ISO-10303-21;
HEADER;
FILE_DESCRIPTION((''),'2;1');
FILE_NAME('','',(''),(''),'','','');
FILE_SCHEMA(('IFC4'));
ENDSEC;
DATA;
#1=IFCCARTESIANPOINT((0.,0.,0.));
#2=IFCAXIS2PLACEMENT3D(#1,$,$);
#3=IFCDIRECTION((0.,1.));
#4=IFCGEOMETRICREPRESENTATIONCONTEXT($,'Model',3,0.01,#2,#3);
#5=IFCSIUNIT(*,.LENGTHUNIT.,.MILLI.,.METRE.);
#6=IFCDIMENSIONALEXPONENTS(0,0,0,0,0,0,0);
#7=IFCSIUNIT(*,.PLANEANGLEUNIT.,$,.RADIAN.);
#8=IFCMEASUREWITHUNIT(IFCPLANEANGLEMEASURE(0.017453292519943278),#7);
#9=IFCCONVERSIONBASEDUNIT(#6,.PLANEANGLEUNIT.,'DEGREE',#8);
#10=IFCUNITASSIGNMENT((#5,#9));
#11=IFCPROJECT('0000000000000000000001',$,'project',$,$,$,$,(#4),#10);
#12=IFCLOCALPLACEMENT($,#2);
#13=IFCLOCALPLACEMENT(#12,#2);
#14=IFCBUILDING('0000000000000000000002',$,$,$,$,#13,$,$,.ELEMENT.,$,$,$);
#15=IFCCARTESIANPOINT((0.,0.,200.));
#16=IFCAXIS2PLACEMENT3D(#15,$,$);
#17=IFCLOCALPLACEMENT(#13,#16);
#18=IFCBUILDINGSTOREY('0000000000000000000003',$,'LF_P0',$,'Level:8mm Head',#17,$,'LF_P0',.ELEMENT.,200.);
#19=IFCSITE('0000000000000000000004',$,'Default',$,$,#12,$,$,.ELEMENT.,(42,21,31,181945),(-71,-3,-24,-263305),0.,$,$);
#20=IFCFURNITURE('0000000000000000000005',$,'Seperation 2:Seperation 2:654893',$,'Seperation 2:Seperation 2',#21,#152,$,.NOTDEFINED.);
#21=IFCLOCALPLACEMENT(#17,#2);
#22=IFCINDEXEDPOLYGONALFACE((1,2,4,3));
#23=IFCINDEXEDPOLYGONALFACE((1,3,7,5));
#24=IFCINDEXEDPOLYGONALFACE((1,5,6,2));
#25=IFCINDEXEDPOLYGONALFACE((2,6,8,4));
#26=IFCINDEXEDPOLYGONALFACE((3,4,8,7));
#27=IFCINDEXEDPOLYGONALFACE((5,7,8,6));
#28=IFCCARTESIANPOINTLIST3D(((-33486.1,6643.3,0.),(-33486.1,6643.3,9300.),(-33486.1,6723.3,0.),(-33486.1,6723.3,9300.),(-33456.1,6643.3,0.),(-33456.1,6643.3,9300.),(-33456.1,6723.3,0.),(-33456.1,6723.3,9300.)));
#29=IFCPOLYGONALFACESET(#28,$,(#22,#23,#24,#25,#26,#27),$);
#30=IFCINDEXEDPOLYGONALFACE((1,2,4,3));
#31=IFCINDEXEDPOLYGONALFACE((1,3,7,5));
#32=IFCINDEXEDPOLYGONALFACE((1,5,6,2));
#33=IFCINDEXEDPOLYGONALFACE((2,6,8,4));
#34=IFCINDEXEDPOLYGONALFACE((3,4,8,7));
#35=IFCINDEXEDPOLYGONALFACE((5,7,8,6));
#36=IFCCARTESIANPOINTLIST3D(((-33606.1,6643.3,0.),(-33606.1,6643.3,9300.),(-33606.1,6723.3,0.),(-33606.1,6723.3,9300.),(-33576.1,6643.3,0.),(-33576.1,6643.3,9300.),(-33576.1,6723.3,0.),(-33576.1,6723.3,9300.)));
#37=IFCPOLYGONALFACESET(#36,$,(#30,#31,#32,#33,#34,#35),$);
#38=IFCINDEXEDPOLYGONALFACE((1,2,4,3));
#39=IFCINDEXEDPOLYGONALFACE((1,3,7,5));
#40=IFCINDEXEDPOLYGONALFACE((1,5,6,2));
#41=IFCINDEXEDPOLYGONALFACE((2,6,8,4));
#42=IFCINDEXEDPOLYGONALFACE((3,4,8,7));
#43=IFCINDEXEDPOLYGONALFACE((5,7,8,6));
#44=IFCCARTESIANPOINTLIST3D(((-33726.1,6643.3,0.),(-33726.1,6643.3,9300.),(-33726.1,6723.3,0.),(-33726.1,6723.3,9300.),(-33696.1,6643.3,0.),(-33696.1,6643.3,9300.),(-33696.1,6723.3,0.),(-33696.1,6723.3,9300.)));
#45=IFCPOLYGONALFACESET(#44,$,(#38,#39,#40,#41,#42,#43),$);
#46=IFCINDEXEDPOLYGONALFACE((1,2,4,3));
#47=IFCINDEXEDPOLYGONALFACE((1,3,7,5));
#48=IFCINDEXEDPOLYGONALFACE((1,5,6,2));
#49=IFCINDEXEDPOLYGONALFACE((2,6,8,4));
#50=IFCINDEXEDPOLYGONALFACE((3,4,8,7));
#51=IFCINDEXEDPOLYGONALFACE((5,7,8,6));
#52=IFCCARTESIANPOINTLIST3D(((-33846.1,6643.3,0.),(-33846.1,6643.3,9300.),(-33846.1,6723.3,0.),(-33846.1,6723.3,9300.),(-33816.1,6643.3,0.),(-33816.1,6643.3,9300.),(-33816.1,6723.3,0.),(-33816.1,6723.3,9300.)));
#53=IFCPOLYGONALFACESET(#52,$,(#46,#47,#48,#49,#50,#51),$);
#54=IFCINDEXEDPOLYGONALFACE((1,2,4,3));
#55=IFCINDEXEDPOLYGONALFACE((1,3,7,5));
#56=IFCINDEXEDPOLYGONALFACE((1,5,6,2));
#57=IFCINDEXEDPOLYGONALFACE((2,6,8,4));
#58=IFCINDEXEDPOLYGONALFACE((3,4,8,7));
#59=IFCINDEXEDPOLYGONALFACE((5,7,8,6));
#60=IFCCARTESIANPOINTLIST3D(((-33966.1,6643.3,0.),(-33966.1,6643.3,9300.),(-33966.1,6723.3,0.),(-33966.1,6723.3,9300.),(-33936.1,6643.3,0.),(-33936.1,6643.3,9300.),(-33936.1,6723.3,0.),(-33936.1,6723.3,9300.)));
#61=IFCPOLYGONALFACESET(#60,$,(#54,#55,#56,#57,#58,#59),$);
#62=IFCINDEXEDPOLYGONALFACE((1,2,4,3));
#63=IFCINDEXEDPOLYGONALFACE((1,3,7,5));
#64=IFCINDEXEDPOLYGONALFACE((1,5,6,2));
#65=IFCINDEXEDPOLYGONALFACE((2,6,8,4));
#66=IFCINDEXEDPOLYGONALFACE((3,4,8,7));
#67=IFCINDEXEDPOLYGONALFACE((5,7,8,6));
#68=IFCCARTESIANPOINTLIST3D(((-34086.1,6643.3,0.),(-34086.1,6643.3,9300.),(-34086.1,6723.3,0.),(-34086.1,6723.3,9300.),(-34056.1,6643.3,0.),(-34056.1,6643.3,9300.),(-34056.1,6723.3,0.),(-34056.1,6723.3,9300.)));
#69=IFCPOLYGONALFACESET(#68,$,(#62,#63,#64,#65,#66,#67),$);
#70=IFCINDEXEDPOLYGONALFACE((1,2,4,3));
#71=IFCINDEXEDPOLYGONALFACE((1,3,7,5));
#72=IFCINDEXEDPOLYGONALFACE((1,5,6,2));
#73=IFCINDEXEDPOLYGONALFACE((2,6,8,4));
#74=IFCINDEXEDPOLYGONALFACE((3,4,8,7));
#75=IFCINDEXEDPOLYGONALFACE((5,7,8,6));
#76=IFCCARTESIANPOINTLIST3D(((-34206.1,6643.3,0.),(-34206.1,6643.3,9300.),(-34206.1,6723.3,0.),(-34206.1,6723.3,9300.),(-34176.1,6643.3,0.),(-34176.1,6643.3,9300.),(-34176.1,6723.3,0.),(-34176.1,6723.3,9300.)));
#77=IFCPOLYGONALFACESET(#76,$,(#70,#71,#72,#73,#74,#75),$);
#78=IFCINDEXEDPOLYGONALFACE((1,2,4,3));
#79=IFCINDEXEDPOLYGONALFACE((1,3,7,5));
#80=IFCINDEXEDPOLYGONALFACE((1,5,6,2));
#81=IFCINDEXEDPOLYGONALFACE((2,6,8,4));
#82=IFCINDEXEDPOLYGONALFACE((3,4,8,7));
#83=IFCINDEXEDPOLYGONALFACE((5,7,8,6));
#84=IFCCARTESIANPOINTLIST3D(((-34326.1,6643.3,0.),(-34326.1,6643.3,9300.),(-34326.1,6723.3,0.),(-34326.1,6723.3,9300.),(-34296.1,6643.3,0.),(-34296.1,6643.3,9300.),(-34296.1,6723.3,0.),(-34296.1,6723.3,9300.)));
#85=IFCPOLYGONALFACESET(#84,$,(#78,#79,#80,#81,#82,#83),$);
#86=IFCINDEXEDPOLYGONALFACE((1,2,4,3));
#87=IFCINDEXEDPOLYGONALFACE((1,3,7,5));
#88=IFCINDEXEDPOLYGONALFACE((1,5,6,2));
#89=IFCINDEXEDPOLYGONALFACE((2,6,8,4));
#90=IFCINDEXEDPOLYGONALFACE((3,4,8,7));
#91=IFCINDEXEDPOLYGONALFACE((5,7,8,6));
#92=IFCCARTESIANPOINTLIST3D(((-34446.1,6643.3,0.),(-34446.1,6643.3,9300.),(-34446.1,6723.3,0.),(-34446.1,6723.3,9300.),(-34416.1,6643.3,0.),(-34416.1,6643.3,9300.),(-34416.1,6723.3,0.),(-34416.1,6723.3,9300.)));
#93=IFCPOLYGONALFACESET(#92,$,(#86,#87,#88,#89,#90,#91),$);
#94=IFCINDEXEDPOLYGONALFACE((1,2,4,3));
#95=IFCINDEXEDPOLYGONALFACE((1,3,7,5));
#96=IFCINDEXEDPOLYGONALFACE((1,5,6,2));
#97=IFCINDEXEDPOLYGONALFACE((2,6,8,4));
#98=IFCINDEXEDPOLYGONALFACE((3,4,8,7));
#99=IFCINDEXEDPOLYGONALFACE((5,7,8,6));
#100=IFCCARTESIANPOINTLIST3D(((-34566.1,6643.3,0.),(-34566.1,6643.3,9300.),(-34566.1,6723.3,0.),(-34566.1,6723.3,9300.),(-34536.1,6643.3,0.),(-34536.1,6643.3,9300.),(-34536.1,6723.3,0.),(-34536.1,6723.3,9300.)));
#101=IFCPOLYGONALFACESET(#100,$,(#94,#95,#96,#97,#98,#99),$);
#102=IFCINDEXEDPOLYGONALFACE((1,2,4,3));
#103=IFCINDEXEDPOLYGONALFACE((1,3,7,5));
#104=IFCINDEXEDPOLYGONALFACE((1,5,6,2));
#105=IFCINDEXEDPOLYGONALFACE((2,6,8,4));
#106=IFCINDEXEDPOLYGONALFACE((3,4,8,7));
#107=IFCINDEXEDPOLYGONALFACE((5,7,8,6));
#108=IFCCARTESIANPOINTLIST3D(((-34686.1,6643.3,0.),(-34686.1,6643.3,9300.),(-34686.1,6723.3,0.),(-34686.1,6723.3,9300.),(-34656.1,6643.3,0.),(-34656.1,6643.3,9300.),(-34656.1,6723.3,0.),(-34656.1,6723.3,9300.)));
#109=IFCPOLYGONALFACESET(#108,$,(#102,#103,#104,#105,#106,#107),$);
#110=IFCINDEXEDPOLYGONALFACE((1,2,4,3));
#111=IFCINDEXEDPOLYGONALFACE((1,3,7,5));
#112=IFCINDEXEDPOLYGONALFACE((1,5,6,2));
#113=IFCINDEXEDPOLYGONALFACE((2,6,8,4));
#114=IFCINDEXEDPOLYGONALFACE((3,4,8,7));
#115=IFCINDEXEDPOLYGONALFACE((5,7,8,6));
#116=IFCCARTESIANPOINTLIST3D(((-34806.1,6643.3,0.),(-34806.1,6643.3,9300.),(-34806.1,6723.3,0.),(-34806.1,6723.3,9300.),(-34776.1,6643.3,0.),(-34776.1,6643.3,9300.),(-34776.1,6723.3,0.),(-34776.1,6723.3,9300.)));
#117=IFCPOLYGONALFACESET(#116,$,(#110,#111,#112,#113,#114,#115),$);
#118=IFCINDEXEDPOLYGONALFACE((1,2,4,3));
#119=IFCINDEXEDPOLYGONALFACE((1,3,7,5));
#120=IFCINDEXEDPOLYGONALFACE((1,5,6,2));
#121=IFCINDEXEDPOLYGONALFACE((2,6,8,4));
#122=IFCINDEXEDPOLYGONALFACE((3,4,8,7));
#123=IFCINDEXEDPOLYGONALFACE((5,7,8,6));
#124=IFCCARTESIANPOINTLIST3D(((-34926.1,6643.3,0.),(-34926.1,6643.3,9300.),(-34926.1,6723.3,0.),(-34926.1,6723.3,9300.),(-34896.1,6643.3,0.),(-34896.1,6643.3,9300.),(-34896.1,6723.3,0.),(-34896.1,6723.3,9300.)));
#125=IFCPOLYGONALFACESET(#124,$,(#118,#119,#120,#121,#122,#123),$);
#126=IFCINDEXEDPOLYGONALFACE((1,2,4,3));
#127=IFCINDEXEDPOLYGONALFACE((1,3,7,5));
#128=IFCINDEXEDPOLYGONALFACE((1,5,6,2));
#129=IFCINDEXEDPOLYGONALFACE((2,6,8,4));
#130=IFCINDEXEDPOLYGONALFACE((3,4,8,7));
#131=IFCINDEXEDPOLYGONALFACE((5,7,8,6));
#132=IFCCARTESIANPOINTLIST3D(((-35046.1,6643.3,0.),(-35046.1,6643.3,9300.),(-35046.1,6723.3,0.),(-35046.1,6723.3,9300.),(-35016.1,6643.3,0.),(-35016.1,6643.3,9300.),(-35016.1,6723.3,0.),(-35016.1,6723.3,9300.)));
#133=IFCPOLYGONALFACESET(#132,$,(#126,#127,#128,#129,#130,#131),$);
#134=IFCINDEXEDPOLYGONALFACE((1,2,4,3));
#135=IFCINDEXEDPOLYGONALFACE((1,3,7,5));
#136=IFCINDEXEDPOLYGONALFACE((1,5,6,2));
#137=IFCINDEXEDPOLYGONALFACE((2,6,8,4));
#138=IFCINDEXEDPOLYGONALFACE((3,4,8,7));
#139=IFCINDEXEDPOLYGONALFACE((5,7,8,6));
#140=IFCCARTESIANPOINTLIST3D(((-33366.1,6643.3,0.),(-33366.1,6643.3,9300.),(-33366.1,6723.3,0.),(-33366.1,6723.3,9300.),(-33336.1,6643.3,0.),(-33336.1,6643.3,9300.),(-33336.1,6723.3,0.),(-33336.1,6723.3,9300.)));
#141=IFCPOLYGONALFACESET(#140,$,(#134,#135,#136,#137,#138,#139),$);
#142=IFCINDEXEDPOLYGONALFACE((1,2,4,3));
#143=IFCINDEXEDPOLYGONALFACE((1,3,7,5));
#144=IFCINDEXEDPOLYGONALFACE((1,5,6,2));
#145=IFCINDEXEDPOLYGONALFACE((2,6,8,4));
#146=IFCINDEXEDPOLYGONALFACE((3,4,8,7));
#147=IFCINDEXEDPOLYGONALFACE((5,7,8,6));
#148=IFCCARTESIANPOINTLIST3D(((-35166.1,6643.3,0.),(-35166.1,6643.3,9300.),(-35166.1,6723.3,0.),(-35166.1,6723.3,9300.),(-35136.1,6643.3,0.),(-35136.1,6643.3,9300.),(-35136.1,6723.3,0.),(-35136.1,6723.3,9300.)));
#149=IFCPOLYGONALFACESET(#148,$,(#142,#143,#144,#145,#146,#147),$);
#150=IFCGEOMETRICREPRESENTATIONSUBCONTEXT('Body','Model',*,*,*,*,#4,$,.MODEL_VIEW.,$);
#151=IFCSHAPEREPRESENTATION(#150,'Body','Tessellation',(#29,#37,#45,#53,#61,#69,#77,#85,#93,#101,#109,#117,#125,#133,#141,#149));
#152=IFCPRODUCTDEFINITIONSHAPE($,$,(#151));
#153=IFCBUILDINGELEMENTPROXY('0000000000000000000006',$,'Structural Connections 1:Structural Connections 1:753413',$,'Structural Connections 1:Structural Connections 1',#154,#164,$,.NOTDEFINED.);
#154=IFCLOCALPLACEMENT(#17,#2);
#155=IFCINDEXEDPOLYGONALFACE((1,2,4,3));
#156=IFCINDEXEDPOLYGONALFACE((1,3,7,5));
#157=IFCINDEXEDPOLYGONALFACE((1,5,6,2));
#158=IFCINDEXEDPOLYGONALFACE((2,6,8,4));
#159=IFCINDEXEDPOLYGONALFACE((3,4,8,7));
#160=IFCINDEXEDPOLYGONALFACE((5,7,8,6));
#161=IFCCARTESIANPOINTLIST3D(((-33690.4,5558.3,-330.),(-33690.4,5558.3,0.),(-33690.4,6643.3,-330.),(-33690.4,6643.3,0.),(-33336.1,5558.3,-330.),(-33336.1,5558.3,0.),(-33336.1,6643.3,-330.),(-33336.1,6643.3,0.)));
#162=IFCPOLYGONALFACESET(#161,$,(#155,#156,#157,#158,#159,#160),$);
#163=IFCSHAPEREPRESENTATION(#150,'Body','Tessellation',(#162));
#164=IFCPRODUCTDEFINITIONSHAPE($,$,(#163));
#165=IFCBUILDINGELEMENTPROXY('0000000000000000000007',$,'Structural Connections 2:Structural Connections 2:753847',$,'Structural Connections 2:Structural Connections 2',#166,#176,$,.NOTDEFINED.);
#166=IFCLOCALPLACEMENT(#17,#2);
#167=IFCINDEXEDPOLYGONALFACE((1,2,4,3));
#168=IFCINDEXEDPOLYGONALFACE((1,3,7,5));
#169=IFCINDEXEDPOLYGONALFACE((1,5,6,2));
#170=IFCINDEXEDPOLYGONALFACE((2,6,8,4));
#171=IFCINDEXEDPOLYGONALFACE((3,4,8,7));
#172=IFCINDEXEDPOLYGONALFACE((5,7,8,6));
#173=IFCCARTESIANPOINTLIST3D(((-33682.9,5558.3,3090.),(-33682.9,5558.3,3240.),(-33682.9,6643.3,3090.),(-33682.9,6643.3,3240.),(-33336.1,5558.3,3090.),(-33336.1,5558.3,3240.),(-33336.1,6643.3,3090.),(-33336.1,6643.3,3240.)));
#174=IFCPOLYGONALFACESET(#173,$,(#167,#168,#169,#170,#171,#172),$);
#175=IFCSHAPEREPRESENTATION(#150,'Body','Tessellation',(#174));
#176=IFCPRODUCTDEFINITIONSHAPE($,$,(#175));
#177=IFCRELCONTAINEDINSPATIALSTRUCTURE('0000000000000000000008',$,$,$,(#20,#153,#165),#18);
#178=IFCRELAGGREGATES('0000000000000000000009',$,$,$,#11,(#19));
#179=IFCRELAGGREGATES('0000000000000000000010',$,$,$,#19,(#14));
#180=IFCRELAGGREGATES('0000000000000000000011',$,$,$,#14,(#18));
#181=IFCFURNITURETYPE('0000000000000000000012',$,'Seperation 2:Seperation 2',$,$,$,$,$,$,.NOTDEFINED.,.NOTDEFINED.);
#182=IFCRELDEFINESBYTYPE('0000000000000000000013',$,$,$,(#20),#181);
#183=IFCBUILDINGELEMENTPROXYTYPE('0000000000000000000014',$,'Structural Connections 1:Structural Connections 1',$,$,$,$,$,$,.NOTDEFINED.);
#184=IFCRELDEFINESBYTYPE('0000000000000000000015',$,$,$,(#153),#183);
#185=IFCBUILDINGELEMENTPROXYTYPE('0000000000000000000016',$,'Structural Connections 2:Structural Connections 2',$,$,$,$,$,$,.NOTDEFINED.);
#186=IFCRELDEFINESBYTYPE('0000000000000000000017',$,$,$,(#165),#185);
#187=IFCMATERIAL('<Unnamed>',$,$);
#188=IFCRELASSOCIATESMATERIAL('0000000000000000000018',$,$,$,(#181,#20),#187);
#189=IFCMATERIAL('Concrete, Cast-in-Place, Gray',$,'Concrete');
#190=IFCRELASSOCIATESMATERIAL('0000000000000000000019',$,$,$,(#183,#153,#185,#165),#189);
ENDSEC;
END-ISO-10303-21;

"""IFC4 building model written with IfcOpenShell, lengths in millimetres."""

from ifc_helpers import new_model, entity, si_unit, converted_unit, direction, frame, origin, place, context, subcontext, project, spatial, indexed_curve, outline, extrude, source, transform, mapped, material, type_object, type_shapes, element, save


model = new_model("IFC4")

# Units and contexts
model_context = context("Model", 3, precision=0.01, world=origin(), true_north=direction((0.0, 1.0)))
body_context = subcontext(model_context, "Body", "Model", "MODEL_VIEW")
ifc_project = project(units=[si_unit("LENGTHUNIT", "METRE", prefix="MILLI"), converted_unit("PLANEANGLEUNIT", "DEGREE", entity("IfcPlaneAngleMeasure", 0.017453292519943278), si_unit("PLANEANGLEUNIT", "RADIAN"), dimensions=[0, 0, 0, 0, 0, 0, 0])], contexts=[model_context])

# Site, building, storey
site_placement = place(None, origin())
site = spatial("IfcSite", under=ifc_project, at=site_placement, Name="Default", CompositionType="ELEMENT", RefLatitude=(42, 21, 31, 181945), RefLongitude=(-71, -3, -24, -263305), RefElevation=0.0)
building_placement = place(site_placement, origin())
building = spatial("IfcBuilding", under=site, at=building_placement, CompositionType="ELEMENT")
storey_placement = place(building_placement, frame((0.0, 0.0, 200.0)))
storey = spatial("IfcBuildingStorey", under=building, at=storey_placement, Name="LF_P0", ObjectType="Level:8mm Head", LongName="LF_P0", CompositionType="ELEMENT", Elevation=200.0)

# Furniture
ifc_material_1 = material(Name="<Unnamed>")
furniture_type_1 = type_object("IfcFurnitureType", Name="Seperation 2:Seperation 2", AssemblyPlace="NOTDEFINED", PredefinedType="NOTDEFINED", material=ifc_material_1)
shared_shape_1 = source(origin(), body_context, "Body", "SweptSolid", [
    extrude(outline(indexed_curve([(-40.0, -15.0), (40.0, -15.0), (40.0, 15.0), (-40.0, 15.0), (-40.0, -15.0)], self_intersect=False)), frame((-33471.1, 6683.3, 200.0), z_axis=(0.0, 0.0, 1.0), x_axis=(0.0, -1.0, 0.0)), (0.0, 0.0, 1.0), 9300.0),
    extrude(outline(indexed_curve([(-40.0, -15.0), (40.0, -15.0), (40.0, 15.0), (-40.0, 15.0), (-40.0, -15.0)], self_intersect=False)), frame((-33591.1, 6683.3, 200.0), z_axis=(0.0, 0.0, 1.0), x_axis=(0.0, -1.0, 0.0)), (0.0, 0.0, 1.0), 9300.0),
    extrude(outline(indexed_curve([(-40.0, -15.0), (40.0, -15.0), (40.0, 15.0), (-40.0, 15.0), (-40.0, -15.0)], self_intersect=False)), frame((-33711.1, 6683.3, 200.0), z_axis=(0.0, 0.0, 1.0), x_axis=(0.0, -1.0, 0.0)), (0.0, 0.0, 1.0), 9300.0),
    extrude(outline(indexed_curve([(-40.0, -15.0), (40.0, -15.0), (40.0, 15.0), (-40.0, 15.0), (-40.0, -15.0)], self_intersect=False)), frame((-33831.1, 6683.3, 200.0), z_axis=(0.0, 0.0, 1.0), x_axis=(0.0, -1.0, 0.0)), (0.0, 0.0, 1.0), 9300.0),
    extrude(outline(indexed_curve([(-40.0, -15.0), (40.0, -15.0), (40.0, 15.0), (-40.0, 15.0), (-40.0, -15.0)], self_intersect=False)), frame((-33951.1, 6683.3, 200.0), z_axis=(0.0, 0.0, 1.0), x_axis=(0.0, -1.0, 0.0)), (0.0, 0.0, 1.0), 9300.0),
    extrude(outline(indexed_curve([(-40.0, -15.0), (40.0, -15.0), (40.0, 15.0), (-40.0, 15.0), (-40.0, -15.0)], self_intersect=False)), frame((-34071.1, 6683.3, 200.0), z_axis=(0.0, 0.0, 1.0), x_axis=(0.0, -1.0, 0.0)), (0.0, 0.0, 1.0), 9300.0),
    extrude(outline(indexed_curve([(-40.0, -15.0), (40.0, -15.0), (40.0, 15.0), (-40.0, 15.0), (-40.0, -15.0)], self_intersect=False)), frame((-34191.1, 6683.3, 200.0), z_axis=(0.0, 0.0, 1.0), x_axis=(0.0, -1.0, 0.0)), (0.0, 0.0, 1.0), 9300.0),
    extrude(outline(indexed_curve([(-40.0, -15.0), (40.0, -15.0), (40.0, 15.0), (-40.0, 15.0), (-40.0, -15.0)], self_intersect=False)), frame((-34311.1, 6683.3, 200.0), z_axis=(0.0, 0.0, 1.0), x_axis=(0.0, -1.0, 0.0)), (0.0, 0.0, 1.0), 9300.0),
    extrude(outline(indexed_curve([(-40.0, -15.0), (40.0, -15.0), (40.0, 15.0), (-40.0, 15.0), (-40.0, -15.0)], self_intersect=False)), frame((-34431.1, 6683.3, 200.0), z_axis=(0.0, 0.0, 1.0), x_axis=(0.0, -1.0, 0.0)), (0.0, 0.0, 1.0), 9300.0),
    extrude(outline(indexed_curve([(-40.0, -15.0), (40.0, -15.0), (40.0, 15.0), (-40.0, 15.0), (-40.0, -15.0)], self_intersect=False)), frame((-34551.1, 6683.3, 200.0), z_axis=(0.0, 0.0, 1.0), x_axis=(0.0, -1.0, 0.0)), (0.0, 0.0, 1.0), 9300.0),
    extrude(outline(indexed_curve([(-40.0, -15.0), (40.0, -15.0), (40.0, 15.0), (-40.0, 15.0), (-40.0, -15.0)], self_intersect=False)), frame((-34671.1, 6683.3, 200.0), z_axis=(0.0, 0.0, 1.0), x_axis=(0.0, -1.0, 0.0)), (0.0, 0.0, 1.0), 9300.0),
    extrude(outline(indexed_curve([(-40.0, -15.0), (40.0, -15.0), (40.0, 15.0), (-40.0, 15.0), (-40.0, -15.0)], self_intersect=False)), frame((-34791.1, 6683.3, 200.0), z_axis=(0.0, 0.0, 1.0), x_axis=(0.0, -1.0, 0.0)), (0.0, 0.0, 1.0), 9300.0),
    extrude(outline(indexed_curve([(-40.0, -15.0), (40.0, -15.0), (40.0, 15.0), (-40.0, 15.0), (-40.0, -15.0)], self_intersect=False)), frame((-34911.1, 6683.3, 200.0), z_axis=(0.0, 0.0, 1.0), x_axis=(0.0, -1.0, 0.0)), (0.0, 0.0, 1.0), 9300.0),
    extrude(outline(indexed_curve([(-40.0, -15.0), (40.0, -15.0), (40.0, 15.0), (-40.0, 15.0), (-40.0, -15.0)], self_intersect=False)), frame((-35031.1, 6683.3, 200.0), z_axis=(0.0, 0.0, 1.0), x_axis=(0.0, -1.0, 0.0)), (0.0, 0.0, 1.0), 9300.0),
    extrude(outline(indexed_curve([(-40.0, -15.0), (40.0, -15.0), (40.0, 15.0), (-40.0, 15.0), (-40.0, -15.0)], self_intersect=False)), frame((-33351.1, 6683.3, 200.0), z_axis=(0.0, 0.0, 1.0), x_axis=(0.0, -1.0, 0.0)), (0.0, 0.0, 1.0), 9300.0),
    extrude(outline(indexed_curve([(-40.0, -15.0), (40.0, -15.0), (40.0, 15.0), (-40.0, 15.0), (-40.0, -15.0)], self_intersect=False)), frame((-35151.1, 6683.3, 200.0), z_axis=(0.0, 0.0, 1.0), x_axis=(0.0, -1.0, 0.0)), (0.0, 0.0, 1.0), 9300.0),
])
type_shapes(furniture_type_1, [shared_shape_1])
furniture_1_placement = place(storey_placement, frame((0.0, 0.0, -200.0)))
element("IfcFurniture", 1, at=furniture_1_placement, inside=storey, type_object=furniture_type_1, material=ifc_material_1, Name="Seperation 2:Seperation 2:654893", ObjectType="Seperation 2:Seperation 2", PredefinedType="NOTDEFINED", context=body_context, shape_type="MappedRepresentation", body=[
    mapped(shared_shape_1, transform((0.0, 0.0, 0.0), scale=1.0)),
])

# Building element proxies
ifc_material_2 = material(Name="Concrete, Cast-in-Place, Gray", Category="Concrete")
building_element_proxy_type_1 = type_object("IfcBuildingElementProxyType", Name="Structural Connections 1:Structural Connections 1", PredefinedType="NOTDEFINED", material=ifc_material_2)
shared_shape_2 = source(origin(), body_context, "Body", "SweptSolid", [
    extrude(outline(indexed_curve([(-177.2, -542.5), (177.2, -542.5), (177.2, 542.5), (-177.2, 542.5), (-177.2, -542.5)], self_intersect=False)), frame((-33513.3, 6100.8, -130.0), z_axis=(0.0, 0.0, 1.0), x_axis=(-1.0, 0.0, 0.0)), (0.0, 0.0, 1.0), 330.0),
])
type_shapes(building_element_proxy_type_1, [shared_shape_2])
proxy_1_placement = place(storey_placement, frame((0.0, 0.0, -200.0)))
element("IfcBuildingElementProxy", 2, at=proxy_1_placement, inside=storey, type_object=building_element_proxy_type_1, material=ifc_material_2, Name="Structural Connections 1:Structural Connections 1:753413", ObjectType="Structural Connections 1:Structural Connections 1", PredefinedType="NOTDEFINED", context=body_context, shape_type="MappedRepresentation", body=[
    mapped(shared_shape_2, transform((0.0, 0.0, 0.0), scale=1.0)),
])
building_element_proxy_type_2 = type_object("IfcBuildingElementProxyType", Name="Structural Connections 2:Structural Connections 2", PredefinedType="NOTDEFINED", material=ifc_material_2)
shared_shape_3 = source(origin(), body_context, "Body", "SweptSolid", [
    extrude(outline(indexed_curve([(-173.4, -542.5), (173.4, -542.5), (173.4, 542.5), (-173.4, 542.5), (-173.4, -542.5)], self_intersect=False)), frame((-33509.5, 6100.8, 3290.0), z_axis=(0.0, 0.0, 1.0), x_axis=(-1.0, 0.0, 0.0)), (0.0, 0.0, 1.0), 150.0),
])
type_shapes(building_element_proxy_type_2, [shared_shape_3])
proxy_2_placement = place(storey_placement, frame((0.0, 0.0, -200.0)))
element("IfcBuildingElementProxy", 3, at=proxy_2_placement, inside=storey, type_object=building_element_proxy_type_2, material=ifc_material_2, Name="Structural Connections 2:Structural Connections 2:753847", ObjectType="Structural Connections 2:Structural Connections 2", PredefinedType="NOTDEFINED", context=body_context, shape_type="MappedRepresentation", body=[
    mapped(shared_shape_3, transform((0.0, 0.0, 0.0), scale=1.0)),
])

save(model, "model.ifc")
